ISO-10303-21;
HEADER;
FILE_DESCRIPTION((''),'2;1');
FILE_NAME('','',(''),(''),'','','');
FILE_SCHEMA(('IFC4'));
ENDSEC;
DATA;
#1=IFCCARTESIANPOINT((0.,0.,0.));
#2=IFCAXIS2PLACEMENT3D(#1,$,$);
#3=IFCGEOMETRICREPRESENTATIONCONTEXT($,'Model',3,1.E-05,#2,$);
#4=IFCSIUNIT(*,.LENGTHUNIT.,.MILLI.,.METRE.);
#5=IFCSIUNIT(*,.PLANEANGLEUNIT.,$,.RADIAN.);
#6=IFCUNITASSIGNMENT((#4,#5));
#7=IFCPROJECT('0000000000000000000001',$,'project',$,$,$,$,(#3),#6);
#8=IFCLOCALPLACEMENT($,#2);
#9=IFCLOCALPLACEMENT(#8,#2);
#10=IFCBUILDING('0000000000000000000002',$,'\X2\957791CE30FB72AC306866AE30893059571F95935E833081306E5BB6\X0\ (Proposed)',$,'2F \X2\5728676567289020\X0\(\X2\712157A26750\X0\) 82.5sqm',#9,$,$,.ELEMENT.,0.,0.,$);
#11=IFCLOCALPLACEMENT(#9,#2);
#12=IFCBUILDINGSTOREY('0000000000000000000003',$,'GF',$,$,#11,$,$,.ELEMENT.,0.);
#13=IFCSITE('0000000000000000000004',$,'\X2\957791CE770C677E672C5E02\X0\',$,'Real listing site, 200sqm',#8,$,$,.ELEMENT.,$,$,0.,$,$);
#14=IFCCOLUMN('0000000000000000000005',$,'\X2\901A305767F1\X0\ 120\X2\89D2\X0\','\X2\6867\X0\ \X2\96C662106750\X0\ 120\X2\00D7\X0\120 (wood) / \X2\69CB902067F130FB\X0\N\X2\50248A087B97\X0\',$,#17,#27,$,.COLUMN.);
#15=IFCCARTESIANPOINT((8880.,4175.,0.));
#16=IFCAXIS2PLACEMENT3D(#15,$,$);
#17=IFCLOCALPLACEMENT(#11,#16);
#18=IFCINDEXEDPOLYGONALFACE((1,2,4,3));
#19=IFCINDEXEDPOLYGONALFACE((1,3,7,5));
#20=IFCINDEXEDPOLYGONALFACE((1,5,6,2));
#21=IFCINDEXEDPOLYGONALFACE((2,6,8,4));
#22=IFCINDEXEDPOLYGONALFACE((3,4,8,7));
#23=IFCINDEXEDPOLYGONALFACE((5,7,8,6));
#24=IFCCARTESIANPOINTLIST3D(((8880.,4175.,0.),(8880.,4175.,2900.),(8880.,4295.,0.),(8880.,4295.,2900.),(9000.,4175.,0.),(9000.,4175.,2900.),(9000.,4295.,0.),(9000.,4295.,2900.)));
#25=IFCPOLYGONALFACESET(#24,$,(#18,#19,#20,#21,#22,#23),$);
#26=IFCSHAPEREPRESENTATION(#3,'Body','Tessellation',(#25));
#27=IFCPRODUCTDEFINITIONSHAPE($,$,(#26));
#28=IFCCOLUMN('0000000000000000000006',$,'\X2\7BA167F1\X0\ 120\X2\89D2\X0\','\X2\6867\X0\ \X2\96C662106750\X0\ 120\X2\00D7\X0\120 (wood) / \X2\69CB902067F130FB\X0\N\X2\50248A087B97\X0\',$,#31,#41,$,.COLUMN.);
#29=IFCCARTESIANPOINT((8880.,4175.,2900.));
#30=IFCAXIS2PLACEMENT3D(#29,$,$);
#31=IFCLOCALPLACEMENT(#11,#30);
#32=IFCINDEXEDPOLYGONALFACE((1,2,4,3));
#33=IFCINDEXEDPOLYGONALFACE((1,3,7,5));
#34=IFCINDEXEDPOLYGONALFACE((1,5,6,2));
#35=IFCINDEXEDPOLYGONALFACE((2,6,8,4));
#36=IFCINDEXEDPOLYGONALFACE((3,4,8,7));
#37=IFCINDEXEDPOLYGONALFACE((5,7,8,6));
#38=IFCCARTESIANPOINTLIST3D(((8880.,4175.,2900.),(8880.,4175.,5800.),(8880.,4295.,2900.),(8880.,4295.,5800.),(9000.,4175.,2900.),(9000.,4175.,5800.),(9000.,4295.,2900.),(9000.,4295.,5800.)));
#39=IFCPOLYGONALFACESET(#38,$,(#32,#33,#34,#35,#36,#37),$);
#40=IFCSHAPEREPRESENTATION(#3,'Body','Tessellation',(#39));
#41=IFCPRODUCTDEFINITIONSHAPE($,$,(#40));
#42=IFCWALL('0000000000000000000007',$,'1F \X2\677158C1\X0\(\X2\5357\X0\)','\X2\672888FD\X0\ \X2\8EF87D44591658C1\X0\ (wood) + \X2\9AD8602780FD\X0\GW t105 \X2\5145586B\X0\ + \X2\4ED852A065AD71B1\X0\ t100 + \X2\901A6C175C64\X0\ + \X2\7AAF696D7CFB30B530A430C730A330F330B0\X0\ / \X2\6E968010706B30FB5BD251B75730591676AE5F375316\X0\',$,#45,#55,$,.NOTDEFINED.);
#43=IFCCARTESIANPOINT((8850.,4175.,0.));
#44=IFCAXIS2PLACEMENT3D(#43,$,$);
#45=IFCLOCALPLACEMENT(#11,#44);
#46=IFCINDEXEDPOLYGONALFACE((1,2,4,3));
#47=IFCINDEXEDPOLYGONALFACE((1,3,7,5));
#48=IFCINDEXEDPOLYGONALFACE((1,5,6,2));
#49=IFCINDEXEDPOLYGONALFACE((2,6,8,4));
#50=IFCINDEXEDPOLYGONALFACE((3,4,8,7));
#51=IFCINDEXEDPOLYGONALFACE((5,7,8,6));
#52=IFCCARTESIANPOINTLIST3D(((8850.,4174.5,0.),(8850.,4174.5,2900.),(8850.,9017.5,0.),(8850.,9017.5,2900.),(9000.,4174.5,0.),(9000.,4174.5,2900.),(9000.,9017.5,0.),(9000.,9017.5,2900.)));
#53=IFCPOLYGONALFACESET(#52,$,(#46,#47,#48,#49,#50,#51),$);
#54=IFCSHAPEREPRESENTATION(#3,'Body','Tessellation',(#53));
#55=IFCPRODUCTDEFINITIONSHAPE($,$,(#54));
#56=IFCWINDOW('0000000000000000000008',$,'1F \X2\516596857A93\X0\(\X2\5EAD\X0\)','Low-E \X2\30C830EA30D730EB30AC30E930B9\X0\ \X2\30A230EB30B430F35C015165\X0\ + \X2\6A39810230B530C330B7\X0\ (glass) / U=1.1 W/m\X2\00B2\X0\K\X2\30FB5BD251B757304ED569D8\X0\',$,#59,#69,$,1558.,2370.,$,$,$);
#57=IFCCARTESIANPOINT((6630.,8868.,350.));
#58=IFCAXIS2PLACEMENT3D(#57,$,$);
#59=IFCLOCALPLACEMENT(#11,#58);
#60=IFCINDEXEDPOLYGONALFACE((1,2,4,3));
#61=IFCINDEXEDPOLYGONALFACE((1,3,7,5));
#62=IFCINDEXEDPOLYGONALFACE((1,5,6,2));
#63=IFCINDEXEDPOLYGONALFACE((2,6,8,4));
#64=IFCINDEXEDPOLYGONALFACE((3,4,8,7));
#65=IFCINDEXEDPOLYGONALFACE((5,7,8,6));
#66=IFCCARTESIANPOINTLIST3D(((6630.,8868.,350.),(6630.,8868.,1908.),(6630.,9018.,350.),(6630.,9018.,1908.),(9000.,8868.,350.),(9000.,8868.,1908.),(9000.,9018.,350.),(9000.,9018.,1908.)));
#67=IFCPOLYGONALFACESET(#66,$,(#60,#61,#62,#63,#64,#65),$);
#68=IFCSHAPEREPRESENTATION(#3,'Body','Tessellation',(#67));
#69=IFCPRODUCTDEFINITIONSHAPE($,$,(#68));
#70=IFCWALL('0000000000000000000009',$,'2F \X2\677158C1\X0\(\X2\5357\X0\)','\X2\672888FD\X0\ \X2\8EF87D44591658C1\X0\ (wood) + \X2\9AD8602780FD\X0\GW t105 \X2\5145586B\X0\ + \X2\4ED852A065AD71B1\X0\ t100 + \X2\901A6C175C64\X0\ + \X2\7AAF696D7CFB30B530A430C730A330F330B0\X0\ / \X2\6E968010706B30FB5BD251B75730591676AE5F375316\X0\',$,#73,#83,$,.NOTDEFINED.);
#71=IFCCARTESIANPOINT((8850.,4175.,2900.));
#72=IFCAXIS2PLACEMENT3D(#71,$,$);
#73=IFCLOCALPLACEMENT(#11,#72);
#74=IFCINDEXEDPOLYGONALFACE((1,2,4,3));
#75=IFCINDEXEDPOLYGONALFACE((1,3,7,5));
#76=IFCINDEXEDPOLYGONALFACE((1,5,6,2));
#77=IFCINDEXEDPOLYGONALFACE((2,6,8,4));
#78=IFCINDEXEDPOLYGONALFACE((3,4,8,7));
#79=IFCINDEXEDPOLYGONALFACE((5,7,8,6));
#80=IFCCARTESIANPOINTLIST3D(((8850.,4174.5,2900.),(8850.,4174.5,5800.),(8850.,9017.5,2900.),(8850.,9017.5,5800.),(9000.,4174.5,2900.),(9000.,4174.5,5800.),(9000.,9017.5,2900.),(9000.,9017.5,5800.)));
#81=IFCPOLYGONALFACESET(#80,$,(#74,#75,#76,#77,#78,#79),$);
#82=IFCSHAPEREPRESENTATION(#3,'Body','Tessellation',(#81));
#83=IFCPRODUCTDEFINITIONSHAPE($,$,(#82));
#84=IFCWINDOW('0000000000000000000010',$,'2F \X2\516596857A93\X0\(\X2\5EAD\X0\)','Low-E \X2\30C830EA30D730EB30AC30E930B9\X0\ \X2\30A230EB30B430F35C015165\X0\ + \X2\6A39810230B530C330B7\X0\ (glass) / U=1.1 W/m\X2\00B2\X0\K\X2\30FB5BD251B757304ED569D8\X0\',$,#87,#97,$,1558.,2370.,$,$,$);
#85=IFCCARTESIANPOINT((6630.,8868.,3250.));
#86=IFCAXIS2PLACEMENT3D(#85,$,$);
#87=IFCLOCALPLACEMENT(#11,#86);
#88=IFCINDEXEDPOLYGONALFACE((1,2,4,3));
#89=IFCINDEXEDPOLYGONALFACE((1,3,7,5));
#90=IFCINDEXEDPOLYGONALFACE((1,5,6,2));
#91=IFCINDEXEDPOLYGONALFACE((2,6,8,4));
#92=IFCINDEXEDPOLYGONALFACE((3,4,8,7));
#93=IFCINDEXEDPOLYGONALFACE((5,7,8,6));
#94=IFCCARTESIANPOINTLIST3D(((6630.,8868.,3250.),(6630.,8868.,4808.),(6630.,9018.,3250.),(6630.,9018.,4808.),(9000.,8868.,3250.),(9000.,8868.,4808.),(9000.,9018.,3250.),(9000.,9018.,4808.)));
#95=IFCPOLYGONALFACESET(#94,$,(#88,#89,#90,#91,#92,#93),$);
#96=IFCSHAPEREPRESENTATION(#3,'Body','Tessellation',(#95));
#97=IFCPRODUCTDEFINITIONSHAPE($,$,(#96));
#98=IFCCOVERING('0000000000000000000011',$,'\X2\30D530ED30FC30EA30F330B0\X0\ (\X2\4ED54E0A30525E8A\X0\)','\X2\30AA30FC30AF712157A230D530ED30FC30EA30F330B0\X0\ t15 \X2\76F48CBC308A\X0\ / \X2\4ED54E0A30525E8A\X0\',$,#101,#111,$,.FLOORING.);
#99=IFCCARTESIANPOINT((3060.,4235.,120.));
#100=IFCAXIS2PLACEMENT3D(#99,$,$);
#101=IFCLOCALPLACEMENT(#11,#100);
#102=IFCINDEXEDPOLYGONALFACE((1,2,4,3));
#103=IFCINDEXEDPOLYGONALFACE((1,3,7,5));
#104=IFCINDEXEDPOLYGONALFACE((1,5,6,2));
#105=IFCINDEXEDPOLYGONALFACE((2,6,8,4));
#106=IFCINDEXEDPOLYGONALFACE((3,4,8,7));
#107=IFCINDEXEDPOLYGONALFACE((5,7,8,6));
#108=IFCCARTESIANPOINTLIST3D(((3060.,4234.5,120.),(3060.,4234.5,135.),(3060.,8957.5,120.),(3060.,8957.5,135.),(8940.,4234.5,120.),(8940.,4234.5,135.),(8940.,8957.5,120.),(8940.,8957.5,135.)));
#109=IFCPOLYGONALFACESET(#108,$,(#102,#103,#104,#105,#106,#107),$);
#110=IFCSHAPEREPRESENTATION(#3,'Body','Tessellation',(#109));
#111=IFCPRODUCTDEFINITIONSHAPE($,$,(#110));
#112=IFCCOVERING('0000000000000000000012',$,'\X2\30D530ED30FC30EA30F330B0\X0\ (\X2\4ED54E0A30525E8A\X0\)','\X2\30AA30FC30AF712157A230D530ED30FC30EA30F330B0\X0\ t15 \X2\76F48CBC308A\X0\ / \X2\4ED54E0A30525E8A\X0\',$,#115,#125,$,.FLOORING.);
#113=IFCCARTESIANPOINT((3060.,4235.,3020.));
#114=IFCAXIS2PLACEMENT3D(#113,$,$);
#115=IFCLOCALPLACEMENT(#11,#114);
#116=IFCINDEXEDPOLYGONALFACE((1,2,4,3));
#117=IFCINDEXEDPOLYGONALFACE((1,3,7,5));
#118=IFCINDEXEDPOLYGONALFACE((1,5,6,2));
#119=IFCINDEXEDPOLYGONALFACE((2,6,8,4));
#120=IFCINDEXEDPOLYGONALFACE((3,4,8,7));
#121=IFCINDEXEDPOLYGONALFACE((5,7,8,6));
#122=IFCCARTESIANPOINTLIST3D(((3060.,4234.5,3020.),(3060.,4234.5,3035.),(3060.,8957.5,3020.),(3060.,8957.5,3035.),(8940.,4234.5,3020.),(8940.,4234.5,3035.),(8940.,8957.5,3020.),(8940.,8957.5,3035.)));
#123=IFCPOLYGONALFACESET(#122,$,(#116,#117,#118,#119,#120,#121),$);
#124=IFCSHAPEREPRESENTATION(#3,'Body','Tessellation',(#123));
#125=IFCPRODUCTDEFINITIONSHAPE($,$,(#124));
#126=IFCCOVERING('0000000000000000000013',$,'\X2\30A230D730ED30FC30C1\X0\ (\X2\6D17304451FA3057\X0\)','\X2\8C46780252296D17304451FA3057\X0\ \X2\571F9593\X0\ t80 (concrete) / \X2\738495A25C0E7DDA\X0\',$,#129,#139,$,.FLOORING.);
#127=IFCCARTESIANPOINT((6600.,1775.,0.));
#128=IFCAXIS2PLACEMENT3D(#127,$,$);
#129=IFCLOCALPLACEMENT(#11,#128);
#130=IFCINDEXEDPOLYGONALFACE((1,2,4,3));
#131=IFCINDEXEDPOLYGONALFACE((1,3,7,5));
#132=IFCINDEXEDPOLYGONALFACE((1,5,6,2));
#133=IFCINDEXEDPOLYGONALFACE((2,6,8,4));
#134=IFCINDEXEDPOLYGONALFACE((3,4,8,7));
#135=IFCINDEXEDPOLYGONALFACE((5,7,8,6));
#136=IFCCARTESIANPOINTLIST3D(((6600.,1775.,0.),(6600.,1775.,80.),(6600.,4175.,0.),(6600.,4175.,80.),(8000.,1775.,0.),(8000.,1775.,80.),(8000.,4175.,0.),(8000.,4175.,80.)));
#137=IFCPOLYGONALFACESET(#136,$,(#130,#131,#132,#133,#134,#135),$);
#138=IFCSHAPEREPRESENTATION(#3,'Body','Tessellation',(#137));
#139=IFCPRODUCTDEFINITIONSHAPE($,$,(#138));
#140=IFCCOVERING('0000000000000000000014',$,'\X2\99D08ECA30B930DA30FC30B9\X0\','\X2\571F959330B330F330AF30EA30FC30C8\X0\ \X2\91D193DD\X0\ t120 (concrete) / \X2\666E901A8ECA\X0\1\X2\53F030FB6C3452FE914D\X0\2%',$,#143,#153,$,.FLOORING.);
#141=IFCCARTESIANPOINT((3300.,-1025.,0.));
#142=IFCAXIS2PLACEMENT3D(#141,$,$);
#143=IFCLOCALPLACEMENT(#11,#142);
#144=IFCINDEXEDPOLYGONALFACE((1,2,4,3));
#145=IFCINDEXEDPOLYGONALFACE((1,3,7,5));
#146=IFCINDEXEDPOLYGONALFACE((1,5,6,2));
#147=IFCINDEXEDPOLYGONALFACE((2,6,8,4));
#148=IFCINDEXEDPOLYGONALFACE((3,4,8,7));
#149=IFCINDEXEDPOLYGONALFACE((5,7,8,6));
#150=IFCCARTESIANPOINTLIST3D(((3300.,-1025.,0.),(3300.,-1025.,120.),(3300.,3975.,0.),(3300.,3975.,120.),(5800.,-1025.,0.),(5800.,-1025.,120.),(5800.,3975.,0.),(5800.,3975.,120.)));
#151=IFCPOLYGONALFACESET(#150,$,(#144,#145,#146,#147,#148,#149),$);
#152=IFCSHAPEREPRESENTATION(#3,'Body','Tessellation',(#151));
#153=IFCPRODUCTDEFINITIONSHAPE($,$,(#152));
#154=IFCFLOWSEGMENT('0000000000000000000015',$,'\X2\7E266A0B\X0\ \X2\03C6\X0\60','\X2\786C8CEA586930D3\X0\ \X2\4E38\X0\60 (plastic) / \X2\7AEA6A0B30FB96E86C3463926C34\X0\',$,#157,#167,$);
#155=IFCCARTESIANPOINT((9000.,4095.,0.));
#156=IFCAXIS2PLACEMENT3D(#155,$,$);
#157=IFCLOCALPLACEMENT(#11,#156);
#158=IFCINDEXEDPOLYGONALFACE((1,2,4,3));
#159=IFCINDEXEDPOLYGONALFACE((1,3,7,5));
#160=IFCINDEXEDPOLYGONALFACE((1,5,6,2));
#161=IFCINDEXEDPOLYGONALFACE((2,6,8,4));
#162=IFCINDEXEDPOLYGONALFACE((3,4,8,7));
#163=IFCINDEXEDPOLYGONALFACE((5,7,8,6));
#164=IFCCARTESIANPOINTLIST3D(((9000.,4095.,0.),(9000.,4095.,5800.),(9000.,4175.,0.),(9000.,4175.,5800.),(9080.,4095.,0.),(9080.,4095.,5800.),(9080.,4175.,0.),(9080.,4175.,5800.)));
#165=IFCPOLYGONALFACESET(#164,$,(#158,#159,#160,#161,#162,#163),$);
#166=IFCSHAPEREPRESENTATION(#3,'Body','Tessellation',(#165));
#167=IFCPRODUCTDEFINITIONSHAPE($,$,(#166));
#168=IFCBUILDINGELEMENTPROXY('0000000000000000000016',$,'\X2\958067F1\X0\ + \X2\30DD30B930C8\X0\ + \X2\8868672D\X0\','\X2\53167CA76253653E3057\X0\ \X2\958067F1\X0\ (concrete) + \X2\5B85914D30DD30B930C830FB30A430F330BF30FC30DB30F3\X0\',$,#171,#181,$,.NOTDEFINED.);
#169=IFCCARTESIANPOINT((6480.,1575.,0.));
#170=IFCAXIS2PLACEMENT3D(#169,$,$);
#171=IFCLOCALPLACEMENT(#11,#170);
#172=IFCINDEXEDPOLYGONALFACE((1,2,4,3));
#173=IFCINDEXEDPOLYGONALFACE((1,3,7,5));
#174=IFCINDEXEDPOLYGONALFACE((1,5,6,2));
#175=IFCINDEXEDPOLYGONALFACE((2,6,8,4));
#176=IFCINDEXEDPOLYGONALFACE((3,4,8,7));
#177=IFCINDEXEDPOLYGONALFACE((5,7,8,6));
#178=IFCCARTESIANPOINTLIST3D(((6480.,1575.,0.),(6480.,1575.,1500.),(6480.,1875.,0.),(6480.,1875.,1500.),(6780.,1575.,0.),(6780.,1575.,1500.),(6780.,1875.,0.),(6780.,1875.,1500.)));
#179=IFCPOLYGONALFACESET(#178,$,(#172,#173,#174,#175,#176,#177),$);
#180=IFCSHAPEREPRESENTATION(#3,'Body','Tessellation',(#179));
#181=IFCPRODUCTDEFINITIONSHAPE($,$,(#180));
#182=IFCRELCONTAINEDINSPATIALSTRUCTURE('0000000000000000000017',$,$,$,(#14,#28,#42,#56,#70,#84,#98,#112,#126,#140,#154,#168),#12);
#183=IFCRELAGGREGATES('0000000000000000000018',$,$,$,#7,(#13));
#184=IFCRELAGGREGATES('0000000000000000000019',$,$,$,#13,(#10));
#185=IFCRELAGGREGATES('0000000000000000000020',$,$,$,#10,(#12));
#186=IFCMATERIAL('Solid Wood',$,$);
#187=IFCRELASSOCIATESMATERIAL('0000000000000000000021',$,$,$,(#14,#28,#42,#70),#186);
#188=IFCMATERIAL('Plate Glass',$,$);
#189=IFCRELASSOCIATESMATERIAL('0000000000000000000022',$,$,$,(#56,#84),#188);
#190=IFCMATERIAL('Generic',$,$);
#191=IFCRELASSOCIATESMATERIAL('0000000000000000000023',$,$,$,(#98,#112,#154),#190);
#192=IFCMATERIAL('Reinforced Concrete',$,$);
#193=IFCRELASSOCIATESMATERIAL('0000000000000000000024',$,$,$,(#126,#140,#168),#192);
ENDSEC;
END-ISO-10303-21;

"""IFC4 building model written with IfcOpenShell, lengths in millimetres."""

from ifc_helpers import new_model, si_unit, frame, frame_2d, origin, place, context, project, spatial, rectangle, extrude, material, element, fill, save


model = new_model("IFC4")

# Units and contexts
model_context = context("Model", 3, precision=1e-05, world=origin())
ifc_project = project(units=[si_unit("LENGTHUNIT", "METRE", prefix="MILLI"), si_unit("PLANEANGLEUNIT", "RADIAN")], contexts=[model_context])

# Site, building, storey
site_placement = place(None, origin())
site = spatial("IfcSite", under=ifc_project, at=site_placement, Name="長野県松本市", ObjectType="Real listing site, 200sqm", CompositionType="ELEMENT", RefElevation=0.0)
building_placement = place(site_placement, origin())
building = spatial("IfcBuilding", under=site, at=building_placement, Name="長野・犬と暮らす土間広めの家 (Proposed)", ObjectType="2F 在来木造(無垢材) 82.5sqm", CompositionType="ELEMENT", ElevationOfRefHeight=0.0, ElevationOfTerrain=0.0)
storey_placement = place(building_placement, origin())
storey = spatial("IfcBuildingStorey", under=building, at=storey_placement, Name="GF", CompositionType="ELEMENT", Elevation=0.0)

# Columns
ifc_material_1 = material(Name="Solid Wood")
column_1_placement = place(storey_placement, frame((8880.0, 4175.0, 0.0)))
element("IfcColumn", 1, at=column_1_placement, inside=storey, material=ifc_material_1, Name="通し柱 120角", Description="桧 集成材 120×120 (wood) / 構造柱・N値計算", PredefinedType="COLUMN", context=model_context, shape_type="SweptSolid", body=[
    extrude(rectangle(XDim=120.0, YDim=120.0, at=frame_2d((60.0, 60.0))), frame((8880.0, 4175.0, 0.0)), (0.0, 0.0, 1.0), 2900.0),
])
column_2_placement = place(storey_placement, frame((8880.0, 4175.0, 2900.0)))
element("IfcColumn", 2, at=column_2_placement, inside=storey, material=ifc_material_1, Name="管柱 120角", Description="桧 集成材 120×120 (wood) / 構造柱・N値計算", PredefinedType="COLUMN", context=model_context, shape_type="SweptSolid", body=[
    extrude(rectangle(XDim=120.0, YDim=120.0, at=frame_2d((60.0, 60.0))), frame((8880.0, 4175.0, 2900.0)), (0.0, 0.0, 1.0), 2900.0),
])

# Wall, opening, window
wall_1_placement = place(storey_placement, frame((8850.0, 4175.0, 0.0)))
wall_1 = element("IfcWall", 3, at=wall_1_placement, inside=storey, material=ifc_material_1, Name="1F 東壁(南)", Description="木製 軸組外壁 (wood) + 高性能GW t105 充填 + 付加断熱 t100 + 通気層 + 窯業系サイディング / 準耐火・寒冷地外皮強化", PredefinedType="NOTDEFINED", context=model_context, shape_type="SweptSolid", body=[
    extrude(rectangle(XDim=150.0, YDim=4843.0, at=frame_2d((75.0, 2421.0))), frame((8850.0, 4175.0, 0.0)), (0.0, 0.0, 1.0), 2900.0),
])
opening_1_placement = place(storey_placement, frame((6630.0, 8868.0, 350.0)))
opening_1 = element("IfcOpeningElement", 4, at=opening_1_placement, cuts=wall_1, PredefinedType="NOTDEFINED", context=model_context, shape_type="SweptSolid", body=[
    extrude(rectangle(XDim=2370.0, YDim=150.0, at=frame_2d((1185.0, 75.0))), frame((6630.0, 8868.0, 350.0)), (0.0, 0.0, 1.0), 1558.0),
])
ifc_material_2 = material(Name="Plate Glass")
window_1_placement = place(storey_placement, frame((6630.0, 8868.0, 350.0)))
window_1 = element("IfcWindow", 5, at=window_1_placement, inside=storey, material=ifc_material_2, Name="1F 入隅窓(庭)", Description="Low-E トリプルガラス アルゴン封入 + 樹脂サッシ (glass) / U=1.1 W/m²K・寒冷地仕様", OverallHeight=1558.0, OverallWidth=2370.0, context=model_context, shape_type="SweptSolid", body=[
    extrude(rectangle(XDim=2370.0, YDim=150.0, at=frame_2d((1185.0, 75.0))), frame((6630.0, 8868.0, 350.0)), (0.0, 0.0, 1.0), 1558.0),
])
fill(opening_1, window_1)

# Wall, opening, window
wall_2_placement = place(storey_placement, frame((8850.0, 4175.0, 2900.0)))
wall_2 = element("IfcWall", 6, at=wall_2_placement, inside=storey, material=ifc_material_1, Name="2F 東壁(南)", Description="木製 軸組外壁 (wood) + 高性能GW t105 充填 + 付加断熱 t100 + 通気層 + 窯業系サイディング / 準耐火・寒冷地外皮強化", PredefinedType="NOTDEFINED", context=model_context, shape_type="SweptSolid", body=[
    extrude(rectangle(XDim=150.0, YDim=4843.0, at=frame_2d((75.0, 2421.0))), frame((8850.0, 4175.0, 2900.0)), (0.0, 0.0, 1.0), 2900.0),
])
opening_2_placement = place(storey_placement, frame((6630.0, 8868.0, 3250.0)))
opening_2 = element("IfcOpeningElement", 7, at=opening_2_placement, cuts=wall_2, PredefinedType="NOTDEFINED", context=model_context, shape_type="SweptSolid", body=[
    extrude(rectangle(XDim=2370.0, YDim=150.0, at=frame_2d((1185.0, 75.0))), frame((6630.0, 8868.0, 3250.0)), (0.0, 0.0, 1.0), 1558.0),
])
window_2_placement = place(storey_placement, frame((6630.0, 8868.0, 3250.0)))
window_2 = element("IfcWindow", 8, at=window_2_placement, inside=storey, material=ifc_material_2, Name="2F 入隅窓(庭)", Description="Low-E トリプルガラス アルゴン封入 + 樹脂サッシ (glass) / U=1.1 W/m²K・寒冷地仕様", OverallHeight=1558.0, OverallWidth=2370.0, context=model_context, shape_type="SweptSolid", body=[
    extrude(rectangle(XDim=2370.0, YDim=150.0, at=frame_2d((1185.0, 75.0))), frame((6630.0, 8868.0, 3250.0)), (0.0, 0.0, 1.0), 1558.0),
])
fill(opening_2, window_2)

# Coverings
ifc_material_3 = material(Name="Generic")
covering_1_placement = place(storey_placement, frame((3060.0, 4235.0, 120.0)))
element("IfcCovering", 9, at=covering_1_placement, inside=storey, material=ifc_material_3, Name="フローリング (仕上げ床)", Description="オーク無垢フローリング t15 直貼り / 仕上げ床", PredefinedType="FLOORING", context=model_context, shape_type="SweptSolid", body=[
    extrude(rectangle(XDim=5880.0, YDim=4723.0, at=frame_2d((2940.0, 2361.0))), frame((3060.0, 4235.0, 120.0)), (0.0, 0.0, 1.0), 15.0),
])
covering_2_placement = place(storey_placement, frame((3060.0, 4235.0, 3020.0)))
element("IfcCovering", 10, at=covering_2_placement, inside=storey, material=ifc_material_3, Name="フローリング (仕上げ床)", Description="オーク無垢フローリング t15 直貼り / 仕上げ床", PredefinedType="FLOORING", context=model_context, shape_type="SweptSolid", body=[
    extrude(rectangle(XDim=5880.0, YDim=4723.0, at=frame_2d((2940.0, 2361.0))), frame((3060.0, 4235.0, 3020.0)), (0.0, 0.0, 1.0), 15.0),
])
ifc_material_4 = material(Name="Reinforced Concrete")
covering_3_placement = place(storey_placement, frame((6600.0, 1775.0, 0.0)))
element("IfcCovering", 11, at=covering_3_placement, inside=storey, material=ifc_material_4, Name="アプローチ (洗い出し)", Description="豆砂利洗い出し 土間 t80 (concrete) / 玄関導線", PredefinedType="FLOORING", context=model_context, shape_type="SweptSolid", body=[
    extrude(rectangle(XDim=1400.0, YDim=2400.0, at=frame_2d((700.0, 1200.0))), frame((6600.0, 1775.0, 0.0)), (0.0, 0.0, 1.0), 80.0),
])
covering_4_placement = place(storey_placement, frame((3300.0, -1025.0, 0.0)))
element("IfcCovering", 12, at=covering_4_placement, inside=storey, material=ifc_material_4, Name="駐車スペース", Description="土間コンクリート 金鏝 t120 (concrete) / 普通車1台・水勾配2%", PredefinedType="FLOORING", context=model_context, shape_type="SweptSolid", body=[
    extrude(rectangle(XDim=2500.0, YDim=5000.0, at=frame_2d((1250.0, 2500.0))), frame((3300.0, -1025.0, 0.0)), (0.0, 0.0, 1.0), 120.0),
])

# Flow segment
flow_segment_placement = place(storey_placement, frame((9000.0, 4095.0, 0.0)))
element("IfcFlowSegment", 13, at=flow_segment_placement, inside=storey, material=ifc_material_3, Name="縦樋 φ60", Description="硬質塩ビ 丸60 (plastic) / 竪樋・雨水排水", context=model_context, shape_type="SweptSolid", body=[
    extrude(rectangle(XDim=80.0, YDim=80.0, at=frame_2d((40.0, 40.0))), frame((9000.0, 4095.0, 0.0)), (0.0, 0.0, 1.0), 5800.0),
])

# Building element proxy
proxy_placement = place(storey_placement, frame((6480.0, 1575.0, 0.0)))
element("IfcBuildingElementProxy", 14, at=proxy_placement, inside=storey, material=ifc_material_4, Name="門柱 + ポスト + 表札", Description="化粧打放し 門柱 (concrete) + 宅配ポスト・インターホン", PredefinedType="NOTDEFINED", context=model_context, shape_type="SweptSolid", body=[
    extrude(rectangle(XDim=300.0, YDim=300.0, at=frame_2d((150.0, 150.0))), frame((6480.0, 1575.0, 0.0)), (0.0, 0.0, 1.0), 1500.0),
])

save(model, "model.ifc")
